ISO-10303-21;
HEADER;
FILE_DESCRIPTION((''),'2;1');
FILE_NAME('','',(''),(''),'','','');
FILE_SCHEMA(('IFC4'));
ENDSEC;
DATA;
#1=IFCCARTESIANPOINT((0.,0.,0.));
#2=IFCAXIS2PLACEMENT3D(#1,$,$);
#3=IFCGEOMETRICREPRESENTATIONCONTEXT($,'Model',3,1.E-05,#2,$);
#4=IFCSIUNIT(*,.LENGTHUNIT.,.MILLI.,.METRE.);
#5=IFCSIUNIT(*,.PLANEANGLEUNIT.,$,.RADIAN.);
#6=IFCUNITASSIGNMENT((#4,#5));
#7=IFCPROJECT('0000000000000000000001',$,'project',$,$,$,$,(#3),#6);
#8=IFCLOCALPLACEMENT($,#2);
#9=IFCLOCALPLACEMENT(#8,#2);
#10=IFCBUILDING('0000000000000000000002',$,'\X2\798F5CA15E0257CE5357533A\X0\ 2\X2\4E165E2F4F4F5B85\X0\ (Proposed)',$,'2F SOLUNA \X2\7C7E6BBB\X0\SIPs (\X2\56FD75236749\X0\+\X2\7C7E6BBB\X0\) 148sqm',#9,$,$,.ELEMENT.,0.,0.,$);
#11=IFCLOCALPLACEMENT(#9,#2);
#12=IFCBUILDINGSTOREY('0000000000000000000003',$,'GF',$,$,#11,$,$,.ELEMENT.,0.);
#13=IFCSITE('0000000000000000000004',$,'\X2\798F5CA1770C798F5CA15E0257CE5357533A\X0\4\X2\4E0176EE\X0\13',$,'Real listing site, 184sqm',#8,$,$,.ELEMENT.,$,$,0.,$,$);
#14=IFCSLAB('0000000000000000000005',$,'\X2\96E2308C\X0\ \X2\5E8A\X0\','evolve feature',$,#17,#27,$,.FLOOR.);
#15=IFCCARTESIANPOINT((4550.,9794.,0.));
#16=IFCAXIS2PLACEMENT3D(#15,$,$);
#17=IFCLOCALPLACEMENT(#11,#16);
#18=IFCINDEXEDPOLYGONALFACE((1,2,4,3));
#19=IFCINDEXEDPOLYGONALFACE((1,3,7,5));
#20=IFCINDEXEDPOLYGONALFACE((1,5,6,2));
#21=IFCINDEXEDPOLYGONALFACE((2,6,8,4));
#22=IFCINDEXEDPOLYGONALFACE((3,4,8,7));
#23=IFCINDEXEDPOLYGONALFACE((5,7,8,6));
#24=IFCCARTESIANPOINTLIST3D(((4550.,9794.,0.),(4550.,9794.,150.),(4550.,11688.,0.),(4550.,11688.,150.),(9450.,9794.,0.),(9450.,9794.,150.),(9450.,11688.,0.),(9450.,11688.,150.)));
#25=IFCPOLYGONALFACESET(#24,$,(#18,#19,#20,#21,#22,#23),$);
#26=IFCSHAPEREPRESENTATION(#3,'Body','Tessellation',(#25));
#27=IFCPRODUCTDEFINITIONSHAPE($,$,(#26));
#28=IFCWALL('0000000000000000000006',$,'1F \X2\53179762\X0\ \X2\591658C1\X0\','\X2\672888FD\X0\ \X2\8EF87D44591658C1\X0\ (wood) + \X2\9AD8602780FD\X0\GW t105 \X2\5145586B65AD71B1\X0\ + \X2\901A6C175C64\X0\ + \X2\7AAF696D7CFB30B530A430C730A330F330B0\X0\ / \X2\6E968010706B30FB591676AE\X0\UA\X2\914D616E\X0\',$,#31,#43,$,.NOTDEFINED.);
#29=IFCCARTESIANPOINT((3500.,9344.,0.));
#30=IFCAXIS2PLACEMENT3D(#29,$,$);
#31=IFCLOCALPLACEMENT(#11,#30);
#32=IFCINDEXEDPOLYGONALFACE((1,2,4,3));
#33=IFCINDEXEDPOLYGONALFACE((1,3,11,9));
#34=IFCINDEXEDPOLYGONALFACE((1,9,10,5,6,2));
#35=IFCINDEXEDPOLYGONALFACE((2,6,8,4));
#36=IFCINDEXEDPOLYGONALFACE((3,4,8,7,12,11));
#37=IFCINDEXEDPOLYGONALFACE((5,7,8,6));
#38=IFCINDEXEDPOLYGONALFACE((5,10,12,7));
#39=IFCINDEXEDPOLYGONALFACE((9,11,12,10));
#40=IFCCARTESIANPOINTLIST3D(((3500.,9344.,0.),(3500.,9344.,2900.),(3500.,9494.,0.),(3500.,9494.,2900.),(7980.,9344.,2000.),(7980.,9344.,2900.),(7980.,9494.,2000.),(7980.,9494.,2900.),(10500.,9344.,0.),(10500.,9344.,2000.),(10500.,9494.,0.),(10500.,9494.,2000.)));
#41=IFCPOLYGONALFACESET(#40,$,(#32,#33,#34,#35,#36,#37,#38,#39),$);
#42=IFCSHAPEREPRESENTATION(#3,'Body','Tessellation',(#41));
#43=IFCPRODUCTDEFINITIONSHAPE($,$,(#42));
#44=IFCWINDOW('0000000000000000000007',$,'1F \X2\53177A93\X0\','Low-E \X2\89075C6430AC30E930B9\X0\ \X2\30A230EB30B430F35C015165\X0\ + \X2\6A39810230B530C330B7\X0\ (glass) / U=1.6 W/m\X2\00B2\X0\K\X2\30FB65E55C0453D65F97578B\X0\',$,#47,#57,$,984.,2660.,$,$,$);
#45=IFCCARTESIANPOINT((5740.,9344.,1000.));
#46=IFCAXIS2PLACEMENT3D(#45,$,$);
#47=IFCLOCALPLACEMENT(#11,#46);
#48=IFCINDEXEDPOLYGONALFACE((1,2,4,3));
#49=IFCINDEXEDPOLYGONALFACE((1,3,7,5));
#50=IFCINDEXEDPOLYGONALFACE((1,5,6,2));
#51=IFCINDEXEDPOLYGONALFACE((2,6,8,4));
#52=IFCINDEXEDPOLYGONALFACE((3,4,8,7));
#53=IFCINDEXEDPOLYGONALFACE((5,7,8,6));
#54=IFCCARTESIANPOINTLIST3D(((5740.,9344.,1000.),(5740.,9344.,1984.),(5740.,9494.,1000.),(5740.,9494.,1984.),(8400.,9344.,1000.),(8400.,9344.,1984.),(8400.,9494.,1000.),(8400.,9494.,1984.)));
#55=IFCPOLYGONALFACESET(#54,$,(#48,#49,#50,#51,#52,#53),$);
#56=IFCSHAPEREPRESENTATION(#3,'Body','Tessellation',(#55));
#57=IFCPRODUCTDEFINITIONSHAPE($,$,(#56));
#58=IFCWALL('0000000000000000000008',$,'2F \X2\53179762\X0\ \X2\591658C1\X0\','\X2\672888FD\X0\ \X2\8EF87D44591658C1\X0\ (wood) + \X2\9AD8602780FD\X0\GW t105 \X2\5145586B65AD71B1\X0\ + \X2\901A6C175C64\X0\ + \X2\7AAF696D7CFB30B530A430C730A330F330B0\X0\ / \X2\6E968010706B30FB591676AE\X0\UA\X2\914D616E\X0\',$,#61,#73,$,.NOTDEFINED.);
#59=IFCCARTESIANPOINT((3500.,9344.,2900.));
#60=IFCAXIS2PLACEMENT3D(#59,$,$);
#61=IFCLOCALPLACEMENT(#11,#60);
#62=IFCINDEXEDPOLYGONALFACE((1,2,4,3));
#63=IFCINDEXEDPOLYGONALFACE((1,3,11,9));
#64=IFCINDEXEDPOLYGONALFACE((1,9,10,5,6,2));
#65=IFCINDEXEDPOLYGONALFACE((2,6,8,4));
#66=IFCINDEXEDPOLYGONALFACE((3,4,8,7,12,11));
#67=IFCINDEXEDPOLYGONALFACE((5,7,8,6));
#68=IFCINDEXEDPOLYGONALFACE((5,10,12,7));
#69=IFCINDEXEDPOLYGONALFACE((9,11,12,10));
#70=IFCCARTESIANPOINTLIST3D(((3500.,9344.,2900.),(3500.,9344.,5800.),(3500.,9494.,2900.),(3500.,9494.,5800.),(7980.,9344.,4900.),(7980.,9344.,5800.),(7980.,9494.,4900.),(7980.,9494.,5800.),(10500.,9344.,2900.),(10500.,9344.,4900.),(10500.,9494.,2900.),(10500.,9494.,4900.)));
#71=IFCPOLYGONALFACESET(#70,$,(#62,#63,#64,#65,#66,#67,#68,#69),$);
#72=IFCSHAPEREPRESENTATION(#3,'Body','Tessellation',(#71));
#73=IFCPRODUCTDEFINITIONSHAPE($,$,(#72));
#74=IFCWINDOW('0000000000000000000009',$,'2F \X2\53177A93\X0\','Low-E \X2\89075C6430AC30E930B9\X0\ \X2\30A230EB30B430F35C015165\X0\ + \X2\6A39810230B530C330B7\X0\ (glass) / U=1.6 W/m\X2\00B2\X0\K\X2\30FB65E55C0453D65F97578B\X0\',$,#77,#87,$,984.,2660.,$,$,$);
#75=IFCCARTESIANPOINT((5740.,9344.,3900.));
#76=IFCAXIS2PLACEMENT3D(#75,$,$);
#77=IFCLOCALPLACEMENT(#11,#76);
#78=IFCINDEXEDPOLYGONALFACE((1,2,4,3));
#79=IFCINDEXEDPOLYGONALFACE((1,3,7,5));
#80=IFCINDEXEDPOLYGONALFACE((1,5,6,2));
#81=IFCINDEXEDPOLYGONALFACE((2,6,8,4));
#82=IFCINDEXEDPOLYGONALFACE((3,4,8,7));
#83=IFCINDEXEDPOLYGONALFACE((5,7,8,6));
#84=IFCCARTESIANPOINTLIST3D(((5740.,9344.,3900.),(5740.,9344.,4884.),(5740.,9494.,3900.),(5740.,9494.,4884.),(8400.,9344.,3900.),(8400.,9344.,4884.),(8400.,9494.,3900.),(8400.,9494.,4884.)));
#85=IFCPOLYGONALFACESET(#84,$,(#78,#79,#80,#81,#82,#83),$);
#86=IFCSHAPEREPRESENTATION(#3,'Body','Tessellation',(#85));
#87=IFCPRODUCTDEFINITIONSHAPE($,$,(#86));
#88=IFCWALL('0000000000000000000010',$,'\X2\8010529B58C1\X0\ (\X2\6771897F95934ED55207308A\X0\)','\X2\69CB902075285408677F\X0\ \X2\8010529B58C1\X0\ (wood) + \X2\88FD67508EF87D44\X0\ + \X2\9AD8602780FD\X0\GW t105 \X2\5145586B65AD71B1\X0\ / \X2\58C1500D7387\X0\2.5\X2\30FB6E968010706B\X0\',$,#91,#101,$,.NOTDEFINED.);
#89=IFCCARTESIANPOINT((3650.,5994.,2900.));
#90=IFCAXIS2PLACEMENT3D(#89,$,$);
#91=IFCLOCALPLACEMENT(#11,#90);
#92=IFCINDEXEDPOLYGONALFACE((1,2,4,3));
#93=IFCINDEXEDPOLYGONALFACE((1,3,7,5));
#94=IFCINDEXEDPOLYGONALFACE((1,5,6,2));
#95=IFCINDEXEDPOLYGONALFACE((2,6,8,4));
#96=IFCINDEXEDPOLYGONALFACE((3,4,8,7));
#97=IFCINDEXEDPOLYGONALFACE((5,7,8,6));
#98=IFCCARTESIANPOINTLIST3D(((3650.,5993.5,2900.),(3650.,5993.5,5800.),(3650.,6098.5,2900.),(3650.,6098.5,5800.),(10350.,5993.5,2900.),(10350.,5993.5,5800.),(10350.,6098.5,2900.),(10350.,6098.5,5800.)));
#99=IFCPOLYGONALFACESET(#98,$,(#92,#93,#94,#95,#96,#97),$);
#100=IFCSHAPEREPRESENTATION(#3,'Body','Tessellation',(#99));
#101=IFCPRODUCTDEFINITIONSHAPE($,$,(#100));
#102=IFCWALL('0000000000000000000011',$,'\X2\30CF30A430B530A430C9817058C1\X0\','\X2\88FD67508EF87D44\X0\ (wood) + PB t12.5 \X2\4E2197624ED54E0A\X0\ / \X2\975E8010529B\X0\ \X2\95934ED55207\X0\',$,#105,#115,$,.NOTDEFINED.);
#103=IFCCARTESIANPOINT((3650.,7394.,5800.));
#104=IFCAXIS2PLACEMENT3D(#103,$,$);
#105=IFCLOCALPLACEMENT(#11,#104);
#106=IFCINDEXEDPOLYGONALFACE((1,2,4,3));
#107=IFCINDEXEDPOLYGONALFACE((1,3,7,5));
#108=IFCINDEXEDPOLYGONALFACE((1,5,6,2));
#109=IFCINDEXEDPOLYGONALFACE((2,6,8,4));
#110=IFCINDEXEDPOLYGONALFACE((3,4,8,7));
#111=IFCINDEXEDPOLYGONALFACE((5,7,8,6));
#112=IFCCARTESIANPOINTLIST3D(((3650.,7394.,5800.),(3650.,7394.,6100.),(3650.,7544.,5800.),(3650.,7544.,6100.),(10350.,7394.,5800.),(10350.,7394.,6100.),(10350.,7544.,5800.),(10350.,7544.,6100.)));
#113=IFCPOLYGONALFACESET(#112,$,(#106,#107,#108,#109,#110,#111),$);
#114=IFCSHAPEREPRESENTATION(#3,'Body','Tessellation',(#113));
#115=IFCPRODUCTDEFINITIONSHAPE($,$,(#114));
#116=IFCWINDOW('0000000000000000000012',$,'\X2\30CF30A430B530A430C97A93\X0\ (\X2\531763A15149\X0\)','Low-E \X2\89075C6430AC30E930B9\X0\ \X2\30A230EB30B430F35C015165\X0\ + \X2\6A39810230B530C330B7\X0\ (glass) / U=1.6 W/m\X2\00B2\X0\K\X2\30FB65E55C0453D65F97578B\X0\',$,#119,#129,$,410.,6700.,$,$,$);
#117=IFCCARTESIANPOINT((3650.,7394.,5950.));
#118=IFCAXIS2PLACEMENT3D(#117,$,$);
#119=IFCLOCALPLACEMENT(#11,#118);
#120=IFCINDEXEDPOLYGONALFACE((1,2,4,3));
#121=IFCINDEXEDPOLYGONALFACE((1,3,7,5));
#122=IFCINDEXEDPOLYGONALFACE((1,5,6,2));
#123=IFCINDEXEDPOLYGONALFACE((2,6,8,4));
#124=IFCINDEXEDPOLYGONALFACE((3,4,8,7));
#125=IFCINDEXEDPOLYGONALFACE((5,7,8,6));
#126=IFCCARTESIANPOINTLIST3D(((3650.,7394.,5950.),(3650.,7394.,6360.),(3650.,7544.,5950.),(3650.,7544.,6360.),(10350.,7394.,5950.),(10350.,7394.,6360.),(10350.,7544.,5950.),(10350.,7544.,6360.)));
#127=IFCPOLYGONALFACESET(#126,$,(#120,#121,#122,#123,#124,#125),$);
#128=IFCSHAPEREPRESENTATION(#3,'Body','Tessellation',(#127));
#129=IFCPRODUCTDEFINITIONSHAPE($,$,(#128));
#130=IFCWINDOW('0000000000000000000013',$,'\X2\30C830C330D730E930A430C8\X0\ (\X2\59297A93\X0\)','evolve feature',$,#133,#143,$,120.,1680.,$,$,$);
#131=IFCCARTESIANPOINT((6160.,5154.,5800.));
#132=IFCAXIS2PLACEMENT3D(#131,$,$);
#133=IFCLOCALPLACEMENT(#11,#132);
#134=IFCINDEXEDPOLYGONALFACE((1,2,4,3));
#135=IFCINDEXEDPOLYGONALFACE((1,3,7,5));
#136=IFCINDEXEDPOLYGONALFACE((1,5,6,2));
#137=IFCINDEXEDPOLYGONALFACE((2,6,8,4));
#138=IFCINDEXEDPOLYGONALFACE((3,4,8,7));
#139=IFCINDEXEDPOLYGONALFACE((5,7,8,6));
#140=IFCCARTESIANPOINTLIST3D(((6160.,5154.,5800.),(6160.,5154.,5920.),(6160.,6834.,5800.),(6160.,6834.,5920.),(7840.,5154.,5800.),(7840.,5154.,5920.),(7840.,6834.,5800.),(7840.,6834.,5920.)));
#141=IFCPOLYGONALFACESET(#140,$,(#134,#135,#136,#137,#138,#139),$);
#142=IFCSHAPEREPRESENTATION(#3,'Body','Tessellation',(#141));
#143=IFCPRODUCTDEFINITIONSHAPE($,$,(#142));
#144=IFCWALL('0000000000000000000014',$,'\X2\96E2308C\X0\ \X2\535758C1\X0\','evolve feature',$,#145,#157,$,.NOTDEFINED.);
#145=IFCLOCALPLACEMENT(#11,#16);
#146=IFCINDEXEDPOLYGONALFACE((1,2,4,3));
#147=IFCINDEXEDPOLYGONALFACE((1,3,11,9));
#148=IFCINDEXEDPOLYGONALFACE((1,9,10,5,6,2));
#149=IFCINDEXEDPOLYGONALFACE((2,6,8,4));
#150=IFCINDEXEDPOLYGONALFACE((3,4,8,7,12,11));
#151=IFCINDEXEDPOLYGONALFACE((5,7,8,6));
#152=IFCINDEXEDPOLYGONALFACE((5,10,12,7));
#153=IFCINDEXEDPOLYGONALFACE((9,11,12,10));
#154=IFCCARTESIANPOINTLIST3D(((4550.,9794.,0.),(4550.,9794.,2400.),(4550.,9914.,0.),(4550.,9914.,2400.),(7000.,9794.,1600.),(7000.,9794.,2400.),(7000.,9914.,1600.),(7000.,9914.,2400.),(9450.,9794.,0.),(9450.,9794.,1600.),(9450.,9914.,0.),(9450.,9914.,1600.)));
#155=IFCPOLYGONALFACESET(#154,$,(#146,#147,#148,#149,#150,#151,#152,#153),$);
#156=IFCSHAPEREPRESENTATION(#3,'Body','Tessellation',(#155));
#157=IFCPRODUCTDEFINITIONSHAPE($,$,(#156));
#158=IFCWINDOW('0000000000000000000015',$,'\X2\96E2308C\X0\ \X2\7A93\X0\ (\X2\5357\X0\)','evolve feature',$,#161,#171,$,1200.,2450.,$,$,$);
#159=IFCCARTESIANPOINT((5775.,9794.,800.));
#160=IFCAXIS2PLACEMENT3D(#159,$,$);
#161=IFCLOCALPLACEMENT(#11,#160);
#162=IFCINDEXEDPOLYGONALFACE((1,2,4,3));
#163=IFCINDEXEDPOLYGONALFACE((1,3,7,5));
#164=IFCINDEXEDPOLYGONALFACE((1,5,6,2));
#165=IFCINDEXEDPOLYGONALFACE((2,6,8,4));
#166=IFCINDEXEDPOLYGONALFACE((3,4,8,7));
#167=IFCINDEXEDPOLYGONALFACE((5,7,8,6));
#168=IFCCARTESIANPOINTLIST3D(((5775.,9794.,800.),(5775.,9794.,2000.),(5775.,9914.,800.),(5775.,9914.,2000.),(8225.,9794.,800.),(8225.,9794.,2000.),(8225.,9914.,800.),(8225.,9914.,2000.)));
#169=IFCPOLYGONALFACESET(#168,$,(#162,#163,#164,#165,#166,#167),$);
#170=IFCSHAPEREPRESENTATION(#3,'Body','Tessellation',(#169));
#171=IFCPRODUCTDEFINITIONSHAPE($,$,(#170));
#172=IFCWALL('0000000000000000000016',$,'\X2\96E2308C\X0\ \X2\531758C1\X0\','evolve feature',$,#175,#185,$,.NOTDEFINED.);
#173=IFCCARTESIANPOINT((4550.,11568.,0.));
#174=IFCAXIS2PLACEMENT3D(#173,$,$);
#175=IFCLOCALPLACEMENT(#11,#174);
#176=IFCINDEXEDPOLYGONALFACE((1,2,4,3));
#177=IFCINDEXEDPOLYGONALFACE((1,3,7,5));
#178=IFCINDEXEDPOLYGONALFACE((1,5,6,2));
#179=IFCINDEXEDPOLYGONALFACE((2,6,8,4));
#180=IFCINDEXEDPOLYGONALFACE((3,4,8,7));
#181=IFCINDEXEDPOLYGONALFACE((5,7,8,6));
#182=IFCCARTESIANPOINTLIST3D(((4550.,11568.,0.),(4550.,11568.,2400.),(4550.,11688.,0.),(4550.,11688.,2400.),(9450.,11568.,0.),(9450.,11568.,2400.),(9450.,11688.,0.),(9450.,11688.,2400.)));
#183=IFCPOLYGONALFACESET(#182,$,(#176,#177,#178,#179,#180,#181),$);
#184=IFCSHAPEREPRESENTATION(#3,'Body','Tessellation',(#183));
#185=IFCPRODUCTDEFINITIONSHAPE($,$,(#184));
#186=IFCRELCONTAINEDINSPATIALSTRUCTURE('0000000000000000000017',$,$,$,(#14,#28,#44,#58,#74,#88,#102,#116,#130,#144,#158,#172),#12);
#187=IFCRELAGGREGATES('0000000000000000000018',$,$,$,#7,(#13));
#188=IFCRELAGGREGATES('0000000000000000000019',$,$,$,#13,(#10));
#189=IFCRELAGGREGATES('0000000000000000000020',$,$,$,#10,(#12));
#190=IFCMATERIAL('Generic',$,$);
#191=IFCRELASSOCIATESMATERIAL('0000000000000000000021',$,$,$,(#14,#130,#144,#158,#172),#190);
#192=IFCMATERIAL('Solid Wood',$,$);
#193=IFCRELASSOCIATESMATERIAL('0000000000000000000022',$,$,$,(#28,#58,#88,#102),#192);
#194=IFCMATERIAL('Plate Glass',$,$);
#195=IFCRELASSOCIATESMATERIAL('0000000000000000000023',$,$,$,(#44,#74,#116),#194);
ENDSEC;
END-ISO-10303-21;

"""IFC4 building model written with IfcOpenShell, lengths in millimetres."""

from ifc_helpers import new_model, si_unit, frame, frame_2d, origin, place, context, project, spatial, rectangle, extrude, material, element, fill, save


model = new_model("IFC4")

# Units and contexts
model_context = context("Model", 3, precision=1e-05, world=origin())
ifc_project = project(units=[si_unit("LENGTHUNIT", "METRE", prefix="MILLI"), si_unit("PLANEANGLEUNIT", "RADIAN")], contexts=[model_context])

# Site, building, storey
site_placement = place(None, origin())
site = spatial("IfcSite", under=ifc_project, at=site_placement, Name="福岡県福岡市城南区4丁目13", ObjectType="Real listing site, 184sqm", CompositionType="ELEMENT", RefElevation=0.0)
building_placement = place(site_placement, origin())
building = spatial("IfcBuilding", under=site, at=building_placement, Name="福岡市城南区 2世帯住宅 (Proposed)", ObjectType="2F SOLUNA 籾殻SIPs (国産杉+籾殻) 148sqm", CompositionType="ELEMENT", ElevationOfRefHeight=0.0, ElevationOfTerrain=0.0)
storey_placement = place(building_placement, origin())
storey = spatial("IfcBuildingStorey", under=building, at=storey_placement, Name="GF", CompositionType="ELEMENT", Elevation=0.0)

# Slab
ifc_material_1 = material(Name="Generic")
slab_placement = place(storey_placement, frame((4550.0, 9794.0, 0.0)))
element("IfcSlab", 1, at=slab_placement, inside=storey, material=ifc_material_1, Name="離れ 床", Description="evolve feature", PredefinedType="FLOOR", context=model_context, shape_type="SweptSolid", body=[
    extrude(rectangle(XDim=4900.0, YDim=1894.0, at=frame_2d((2450.0, 947.0))), frame((4550.0, 9794.0, 0.0)), (0.0, 0.0, 1.0), 150.0),
])

# Wall, opening, window
ifc_material_2 = material(Name="Solid Wood")
wall_1_placement = place(storey_placement, frame((3500.0, 9344.0, 0.0)))
wall_1 = element("IfcWall", 2, at=wall_1_placement, inside=storey, material=ifc_material_2, Name="1F 北面 外壁", Description="木製 軸組外壁 (wood) + 高性能GW t105 充填断熱 + 通気層 + 窯業系サイディング / 準耐火・外皮UA配慮", PredefinedType="NOTDEFINED", context=model_context, shape_type="SweptSolid", body=[
    extrude(rectangle(XDim=7000.0, YDim=150.0, at=frame_2d((3500.0, 75.0))), frame((3500.0, 9344.0, 0.0)), (0.0, 0.0, 1.0), 2900.0),
])
opening_1_placement = place(storey_placement, frame((5740.0, 9344.0, 1000.0)))
opening_1 = element("IfcOpeningElement", 3, at=opening_1_placement, cuts=wall_1, PredefinedType="NOTDEFINED", context=model_context, shape_type="SweptSolid", body=[
    extrude(rectangle(XDim=2660.0, YDim=150.0, at=frame_2d((1330.0, 75.0))), frame((5740.0, 9344.0, 1000.0)), (0.0, 0.0, 1.0), 984.0),
])
ifc_material_3 = material(Name="Plate Glass")
window_1_placement = place(storey_placement, frame((5740.0, 9344.0, 1000.0)))
window_1 = element("IfcWindow", 4, at=window_1_placement, inside=storey, material=ifc_material_3, Name="1F 北窓", Description="Low-E 複層ガラス アルゴン封入 + 樹脂サッシ (glass) / U=1.6 W/m²K・日射取得型", OverallHeight=984.0, OverallWidth=2660.0, context=model_context, shape_type="SweptSolid", body=[
    extrude(rectangle(XDim=2660.0, YDim=150.0, at=frame_2d((1330.0, 75.0))), frame((5740.0, 9344.0, 1000.0)), (0.0, 0.0, 1.0), 984.0),
])
fill(opening_1, window_1)

# Wall, opening, window
wall_2_placement = place(storey_placement, frame((3500.0, 9344.0, 2900.0)))
wall_2 = element("IfcWall", 5, at=wall_2_placement, inside=storey, material=ifc_material_2, Name="2F 北面 外壁", Description="木製 軸組外壁 (wood) + 高性能GW t105 充填断熱 + 通気層 + 窯業系サイディング / 準耐火・外皮UA配慮", PredefinedType="NOTDEFINED", context=model_context, shape_type="SweptSolid", body=[
    extrude(rectangle(XDim=7000.0, YDim=150.0, at=frame_2d((3500.0, 75.0))), frame((3500.0, 9344.0, 2900.0)), (0.0, 0.0, 1.0), 2900.0),
])
opening_2_placement = place(storey_placement, frame((5740.0, 9344.0, 3900.0)))
opening_2 = element("IfcOpeningElement", 6, at=opening_2_placement, cuts=wall_2, PredefinedType="NOTDEFINED", context=model_context, shape_type="SweptSolid", body=[
    extrude(rectangle(XDim=2660.0, YDim=150.0, at=frame_2d((1330.0, 75.0))), frame((5740.0, 9344.0, 3900.0)), (0.0, 0.0, 1.0), 984.0),
])
window_2_placement = place(storey_placement, frame((5740.0, 9344.0, 3900.0)))
window_2 = element("IfcWindow", 7, at=window_2_placement, inside=storey, material=ifc_material_3, Name="2F 北窓", Description="Low-E 複層ガラス アルゴン封入 + 樹脂サッシ (glass) / U=1.6 W/m²K・日射取得型", OverallHeight=984.0, OverallWidth=2660.0, context=model_context, shape_type="SweptSolid", body=[
    extrude(rectangle(XDim=2660.0, YDim=150.0, at=frame_2d((1330.0, 75.0))), frame((5740.0, 9344.0, 3900.0)), (0.0, 0.0, 1.0), 984.0),
])
fill(opening_2, window_2)

# Wall
wall_3_placement = place(storey_placement, frame((3650.0, 5994.0, 2900.0)))
element("IfcWall", 8, at=wall_3_placement, inside=storey, material=ifc_material_2, Name="耐力壁 (東西間仕切り)", Description="構造用合板 耐力壁 (wood) + 製材軸組 + 高性能GW t105 充填断熱 / 壁倍率2.5・準耐火", PredefinedType="NOTDEFINED", context=model_context, shape_type="SweptSolid", body=[
    extrude(rectangle(XDim=6700.0, YDim=105.0, at=frame_2d((3350.0, 52.0))), frame((3650.0, 5994.0, 2900.0)), (0.0, 0.0, 1.0), 2900.0),
])

# Wall, opening, window
wall_4_placement = place(storey_placement, frame((3650.0, 7394.0, 5800.0)))
wall_4 = element("IfcWall", 9, at=wall_4_placement, inside=storey, material=ifc_material_2, Name="ハイサイド腰壁", Description="製材軸組 (wood) + PB t12.5 両面仕上 / 非耐力 間仕切", PredefinedType="NOTDEFINED", context=model_context, shape_type="SweptSolid", body=[
    extrude(rectangle(XDim=6700.0, YDim=150.0, at=frame_2d((3350.0, 75.0))), frame((3650.0, 7394.0, 5800.0)), (0.0, 0.0, 1.0), 700.0),
])
opening_3_placement = place(storey_placement, frame((3650.0, 7394.0, 5950.0)))
opening_3 = element("IfcOpeningElement", 10, at=opening_3_placement, cuts=wall_4, PredefinedType="NOTDEFINED", context=model_context, shape_type="SweptSolid", body=[
    extrude(rectangle(XDim=6700.0, YDim=150.0, at=frame_2d((3350.0, 75.0))), frame((3650.0, 7394.0, 5950.0)), (0.0, 0.0, 1.0), 410.0),
])
window_3_placement = place(storey_placement, frame((3650.0, 7394.0, 5950.0)))
window_3 = element("IfcWindow", 11, at=window_3_placement, inside=storey, material=ifc_material_3, Name="ハイサイド窓 (北採光)", Description="Low-E 複層ガラス アルゴン封入 + 樹脂サッシ (glass) / U=1.6 W/m²K・日射取得型", OverallHeight=410.0, OverallWidth=6700.0, context=model_context, shape_type="SweptSolid", body=[
    extrude(rectangle(XDim=6700.0, YDim=150.0, at=frame_2d((3350.0, 75.0))), frame((3650.0, 7394.0, 5950.0)), (0.0, 0.0, 1.0), 410.0),
])
fill(opening_3, window_3)

# Window
window_4_placement = place(storey_placement, frame((6160.0, 5154.0, 5800.0)))
element("IfcWindow", 12, at=window_4_placement, inside=storey, material=ifc_material_1, Name="トップライト (天窓)", Description="evolve feature", OverallHeight=120.0, OverallWidth=1680.0, context=model_context, shape_type="SweptSolid", body=[
    extrude(rectangle(XDim=1680.0, YDim=1680.0, at=frame_2d((840.0, 840.0))), frame((6160.0, 5154.0, 5800.0)), (0.0, 0.0, 1.0), 120.0),
])

# Wall, opening, window
wall_5_placement = place(storey_placement, frame((4550.0, 9794.0, 0.0)))
wall_5 = element("IfcWall", 13, at=wall_5_placement, inside=storey, material=ifc_material_1, Name="離れ 南壁", Description="evolve feature", PredefinedType="NOTDEFINED", context=model_context, shape_type="SweptSolid", body=[
    extrude(rectangle(XDim=4900.0, YDim=120.0, at=frame_2d((2450.0, 60.0))), frame((4550.0, 9794.0, 0.0)), (0.0, 0.0, 1.0), 2400.0),
])
opening_4_placement = place(storey_placement, frame((5775.0, 9794.0, 800.0)))
opening_4 = element("IfcOpeningElement", 14, at=opening_4_placement, cuts=wall_5, PredefinedType="NOTDEFINED", context=model_context, shape_type="SweptSolid", body=[
    extrude(rectangle(XDim=2450.0, YDim=120.0, at=frame_2d((1225.0, 60.0))), frame((5775.0, 9794.0, 800.0)), (0.0, 0.0, 1.0), 1200.0),
])
window_5_placement = place(storey_placement, frame((5775.0, 9794.0, 800.0)))
window_5 = element("IfcWindow", 15, at=window_5_placement, inside=storey, material=ifc_material_1, Name="離れ 窓 (南)", Description="evolve feature", OverallHeight=1200.0, OverallWidth=2450.0, context=model_context, shape_type="SweptSolid", body=[
    extrude(rectangle(XDim=2450.0, YDim=120.0, at=frame_2d((1225.0, 60.0))), frame((5775.0, 9794.0, 800.0)), (0.0, 0.0, 1.0), 1200.0),
])
fill(opening_4, window_5)

# Wall
wall_6_placement = place(storey_placement, frame((4550.0, 11568.0, 0.0)))
element("IfcWall", 16, at=wall_6_placement, inside=storey, material=ifc_material_1, Name="離れ 北壁", Description="evolve feature", PredefinedType="NOTDEFINED", context=model_context, shape_type="SweptSolid", body=[
    extrude(rectangle(XDim=4900.0, YDim=120.0, at=frame_2d((2450.0, 60.0))), frame((4550.0, 11568.0, 0.0)), (0.0, 0.0, 1.0), 2400.0),
])

save(model, "model.ifc")
